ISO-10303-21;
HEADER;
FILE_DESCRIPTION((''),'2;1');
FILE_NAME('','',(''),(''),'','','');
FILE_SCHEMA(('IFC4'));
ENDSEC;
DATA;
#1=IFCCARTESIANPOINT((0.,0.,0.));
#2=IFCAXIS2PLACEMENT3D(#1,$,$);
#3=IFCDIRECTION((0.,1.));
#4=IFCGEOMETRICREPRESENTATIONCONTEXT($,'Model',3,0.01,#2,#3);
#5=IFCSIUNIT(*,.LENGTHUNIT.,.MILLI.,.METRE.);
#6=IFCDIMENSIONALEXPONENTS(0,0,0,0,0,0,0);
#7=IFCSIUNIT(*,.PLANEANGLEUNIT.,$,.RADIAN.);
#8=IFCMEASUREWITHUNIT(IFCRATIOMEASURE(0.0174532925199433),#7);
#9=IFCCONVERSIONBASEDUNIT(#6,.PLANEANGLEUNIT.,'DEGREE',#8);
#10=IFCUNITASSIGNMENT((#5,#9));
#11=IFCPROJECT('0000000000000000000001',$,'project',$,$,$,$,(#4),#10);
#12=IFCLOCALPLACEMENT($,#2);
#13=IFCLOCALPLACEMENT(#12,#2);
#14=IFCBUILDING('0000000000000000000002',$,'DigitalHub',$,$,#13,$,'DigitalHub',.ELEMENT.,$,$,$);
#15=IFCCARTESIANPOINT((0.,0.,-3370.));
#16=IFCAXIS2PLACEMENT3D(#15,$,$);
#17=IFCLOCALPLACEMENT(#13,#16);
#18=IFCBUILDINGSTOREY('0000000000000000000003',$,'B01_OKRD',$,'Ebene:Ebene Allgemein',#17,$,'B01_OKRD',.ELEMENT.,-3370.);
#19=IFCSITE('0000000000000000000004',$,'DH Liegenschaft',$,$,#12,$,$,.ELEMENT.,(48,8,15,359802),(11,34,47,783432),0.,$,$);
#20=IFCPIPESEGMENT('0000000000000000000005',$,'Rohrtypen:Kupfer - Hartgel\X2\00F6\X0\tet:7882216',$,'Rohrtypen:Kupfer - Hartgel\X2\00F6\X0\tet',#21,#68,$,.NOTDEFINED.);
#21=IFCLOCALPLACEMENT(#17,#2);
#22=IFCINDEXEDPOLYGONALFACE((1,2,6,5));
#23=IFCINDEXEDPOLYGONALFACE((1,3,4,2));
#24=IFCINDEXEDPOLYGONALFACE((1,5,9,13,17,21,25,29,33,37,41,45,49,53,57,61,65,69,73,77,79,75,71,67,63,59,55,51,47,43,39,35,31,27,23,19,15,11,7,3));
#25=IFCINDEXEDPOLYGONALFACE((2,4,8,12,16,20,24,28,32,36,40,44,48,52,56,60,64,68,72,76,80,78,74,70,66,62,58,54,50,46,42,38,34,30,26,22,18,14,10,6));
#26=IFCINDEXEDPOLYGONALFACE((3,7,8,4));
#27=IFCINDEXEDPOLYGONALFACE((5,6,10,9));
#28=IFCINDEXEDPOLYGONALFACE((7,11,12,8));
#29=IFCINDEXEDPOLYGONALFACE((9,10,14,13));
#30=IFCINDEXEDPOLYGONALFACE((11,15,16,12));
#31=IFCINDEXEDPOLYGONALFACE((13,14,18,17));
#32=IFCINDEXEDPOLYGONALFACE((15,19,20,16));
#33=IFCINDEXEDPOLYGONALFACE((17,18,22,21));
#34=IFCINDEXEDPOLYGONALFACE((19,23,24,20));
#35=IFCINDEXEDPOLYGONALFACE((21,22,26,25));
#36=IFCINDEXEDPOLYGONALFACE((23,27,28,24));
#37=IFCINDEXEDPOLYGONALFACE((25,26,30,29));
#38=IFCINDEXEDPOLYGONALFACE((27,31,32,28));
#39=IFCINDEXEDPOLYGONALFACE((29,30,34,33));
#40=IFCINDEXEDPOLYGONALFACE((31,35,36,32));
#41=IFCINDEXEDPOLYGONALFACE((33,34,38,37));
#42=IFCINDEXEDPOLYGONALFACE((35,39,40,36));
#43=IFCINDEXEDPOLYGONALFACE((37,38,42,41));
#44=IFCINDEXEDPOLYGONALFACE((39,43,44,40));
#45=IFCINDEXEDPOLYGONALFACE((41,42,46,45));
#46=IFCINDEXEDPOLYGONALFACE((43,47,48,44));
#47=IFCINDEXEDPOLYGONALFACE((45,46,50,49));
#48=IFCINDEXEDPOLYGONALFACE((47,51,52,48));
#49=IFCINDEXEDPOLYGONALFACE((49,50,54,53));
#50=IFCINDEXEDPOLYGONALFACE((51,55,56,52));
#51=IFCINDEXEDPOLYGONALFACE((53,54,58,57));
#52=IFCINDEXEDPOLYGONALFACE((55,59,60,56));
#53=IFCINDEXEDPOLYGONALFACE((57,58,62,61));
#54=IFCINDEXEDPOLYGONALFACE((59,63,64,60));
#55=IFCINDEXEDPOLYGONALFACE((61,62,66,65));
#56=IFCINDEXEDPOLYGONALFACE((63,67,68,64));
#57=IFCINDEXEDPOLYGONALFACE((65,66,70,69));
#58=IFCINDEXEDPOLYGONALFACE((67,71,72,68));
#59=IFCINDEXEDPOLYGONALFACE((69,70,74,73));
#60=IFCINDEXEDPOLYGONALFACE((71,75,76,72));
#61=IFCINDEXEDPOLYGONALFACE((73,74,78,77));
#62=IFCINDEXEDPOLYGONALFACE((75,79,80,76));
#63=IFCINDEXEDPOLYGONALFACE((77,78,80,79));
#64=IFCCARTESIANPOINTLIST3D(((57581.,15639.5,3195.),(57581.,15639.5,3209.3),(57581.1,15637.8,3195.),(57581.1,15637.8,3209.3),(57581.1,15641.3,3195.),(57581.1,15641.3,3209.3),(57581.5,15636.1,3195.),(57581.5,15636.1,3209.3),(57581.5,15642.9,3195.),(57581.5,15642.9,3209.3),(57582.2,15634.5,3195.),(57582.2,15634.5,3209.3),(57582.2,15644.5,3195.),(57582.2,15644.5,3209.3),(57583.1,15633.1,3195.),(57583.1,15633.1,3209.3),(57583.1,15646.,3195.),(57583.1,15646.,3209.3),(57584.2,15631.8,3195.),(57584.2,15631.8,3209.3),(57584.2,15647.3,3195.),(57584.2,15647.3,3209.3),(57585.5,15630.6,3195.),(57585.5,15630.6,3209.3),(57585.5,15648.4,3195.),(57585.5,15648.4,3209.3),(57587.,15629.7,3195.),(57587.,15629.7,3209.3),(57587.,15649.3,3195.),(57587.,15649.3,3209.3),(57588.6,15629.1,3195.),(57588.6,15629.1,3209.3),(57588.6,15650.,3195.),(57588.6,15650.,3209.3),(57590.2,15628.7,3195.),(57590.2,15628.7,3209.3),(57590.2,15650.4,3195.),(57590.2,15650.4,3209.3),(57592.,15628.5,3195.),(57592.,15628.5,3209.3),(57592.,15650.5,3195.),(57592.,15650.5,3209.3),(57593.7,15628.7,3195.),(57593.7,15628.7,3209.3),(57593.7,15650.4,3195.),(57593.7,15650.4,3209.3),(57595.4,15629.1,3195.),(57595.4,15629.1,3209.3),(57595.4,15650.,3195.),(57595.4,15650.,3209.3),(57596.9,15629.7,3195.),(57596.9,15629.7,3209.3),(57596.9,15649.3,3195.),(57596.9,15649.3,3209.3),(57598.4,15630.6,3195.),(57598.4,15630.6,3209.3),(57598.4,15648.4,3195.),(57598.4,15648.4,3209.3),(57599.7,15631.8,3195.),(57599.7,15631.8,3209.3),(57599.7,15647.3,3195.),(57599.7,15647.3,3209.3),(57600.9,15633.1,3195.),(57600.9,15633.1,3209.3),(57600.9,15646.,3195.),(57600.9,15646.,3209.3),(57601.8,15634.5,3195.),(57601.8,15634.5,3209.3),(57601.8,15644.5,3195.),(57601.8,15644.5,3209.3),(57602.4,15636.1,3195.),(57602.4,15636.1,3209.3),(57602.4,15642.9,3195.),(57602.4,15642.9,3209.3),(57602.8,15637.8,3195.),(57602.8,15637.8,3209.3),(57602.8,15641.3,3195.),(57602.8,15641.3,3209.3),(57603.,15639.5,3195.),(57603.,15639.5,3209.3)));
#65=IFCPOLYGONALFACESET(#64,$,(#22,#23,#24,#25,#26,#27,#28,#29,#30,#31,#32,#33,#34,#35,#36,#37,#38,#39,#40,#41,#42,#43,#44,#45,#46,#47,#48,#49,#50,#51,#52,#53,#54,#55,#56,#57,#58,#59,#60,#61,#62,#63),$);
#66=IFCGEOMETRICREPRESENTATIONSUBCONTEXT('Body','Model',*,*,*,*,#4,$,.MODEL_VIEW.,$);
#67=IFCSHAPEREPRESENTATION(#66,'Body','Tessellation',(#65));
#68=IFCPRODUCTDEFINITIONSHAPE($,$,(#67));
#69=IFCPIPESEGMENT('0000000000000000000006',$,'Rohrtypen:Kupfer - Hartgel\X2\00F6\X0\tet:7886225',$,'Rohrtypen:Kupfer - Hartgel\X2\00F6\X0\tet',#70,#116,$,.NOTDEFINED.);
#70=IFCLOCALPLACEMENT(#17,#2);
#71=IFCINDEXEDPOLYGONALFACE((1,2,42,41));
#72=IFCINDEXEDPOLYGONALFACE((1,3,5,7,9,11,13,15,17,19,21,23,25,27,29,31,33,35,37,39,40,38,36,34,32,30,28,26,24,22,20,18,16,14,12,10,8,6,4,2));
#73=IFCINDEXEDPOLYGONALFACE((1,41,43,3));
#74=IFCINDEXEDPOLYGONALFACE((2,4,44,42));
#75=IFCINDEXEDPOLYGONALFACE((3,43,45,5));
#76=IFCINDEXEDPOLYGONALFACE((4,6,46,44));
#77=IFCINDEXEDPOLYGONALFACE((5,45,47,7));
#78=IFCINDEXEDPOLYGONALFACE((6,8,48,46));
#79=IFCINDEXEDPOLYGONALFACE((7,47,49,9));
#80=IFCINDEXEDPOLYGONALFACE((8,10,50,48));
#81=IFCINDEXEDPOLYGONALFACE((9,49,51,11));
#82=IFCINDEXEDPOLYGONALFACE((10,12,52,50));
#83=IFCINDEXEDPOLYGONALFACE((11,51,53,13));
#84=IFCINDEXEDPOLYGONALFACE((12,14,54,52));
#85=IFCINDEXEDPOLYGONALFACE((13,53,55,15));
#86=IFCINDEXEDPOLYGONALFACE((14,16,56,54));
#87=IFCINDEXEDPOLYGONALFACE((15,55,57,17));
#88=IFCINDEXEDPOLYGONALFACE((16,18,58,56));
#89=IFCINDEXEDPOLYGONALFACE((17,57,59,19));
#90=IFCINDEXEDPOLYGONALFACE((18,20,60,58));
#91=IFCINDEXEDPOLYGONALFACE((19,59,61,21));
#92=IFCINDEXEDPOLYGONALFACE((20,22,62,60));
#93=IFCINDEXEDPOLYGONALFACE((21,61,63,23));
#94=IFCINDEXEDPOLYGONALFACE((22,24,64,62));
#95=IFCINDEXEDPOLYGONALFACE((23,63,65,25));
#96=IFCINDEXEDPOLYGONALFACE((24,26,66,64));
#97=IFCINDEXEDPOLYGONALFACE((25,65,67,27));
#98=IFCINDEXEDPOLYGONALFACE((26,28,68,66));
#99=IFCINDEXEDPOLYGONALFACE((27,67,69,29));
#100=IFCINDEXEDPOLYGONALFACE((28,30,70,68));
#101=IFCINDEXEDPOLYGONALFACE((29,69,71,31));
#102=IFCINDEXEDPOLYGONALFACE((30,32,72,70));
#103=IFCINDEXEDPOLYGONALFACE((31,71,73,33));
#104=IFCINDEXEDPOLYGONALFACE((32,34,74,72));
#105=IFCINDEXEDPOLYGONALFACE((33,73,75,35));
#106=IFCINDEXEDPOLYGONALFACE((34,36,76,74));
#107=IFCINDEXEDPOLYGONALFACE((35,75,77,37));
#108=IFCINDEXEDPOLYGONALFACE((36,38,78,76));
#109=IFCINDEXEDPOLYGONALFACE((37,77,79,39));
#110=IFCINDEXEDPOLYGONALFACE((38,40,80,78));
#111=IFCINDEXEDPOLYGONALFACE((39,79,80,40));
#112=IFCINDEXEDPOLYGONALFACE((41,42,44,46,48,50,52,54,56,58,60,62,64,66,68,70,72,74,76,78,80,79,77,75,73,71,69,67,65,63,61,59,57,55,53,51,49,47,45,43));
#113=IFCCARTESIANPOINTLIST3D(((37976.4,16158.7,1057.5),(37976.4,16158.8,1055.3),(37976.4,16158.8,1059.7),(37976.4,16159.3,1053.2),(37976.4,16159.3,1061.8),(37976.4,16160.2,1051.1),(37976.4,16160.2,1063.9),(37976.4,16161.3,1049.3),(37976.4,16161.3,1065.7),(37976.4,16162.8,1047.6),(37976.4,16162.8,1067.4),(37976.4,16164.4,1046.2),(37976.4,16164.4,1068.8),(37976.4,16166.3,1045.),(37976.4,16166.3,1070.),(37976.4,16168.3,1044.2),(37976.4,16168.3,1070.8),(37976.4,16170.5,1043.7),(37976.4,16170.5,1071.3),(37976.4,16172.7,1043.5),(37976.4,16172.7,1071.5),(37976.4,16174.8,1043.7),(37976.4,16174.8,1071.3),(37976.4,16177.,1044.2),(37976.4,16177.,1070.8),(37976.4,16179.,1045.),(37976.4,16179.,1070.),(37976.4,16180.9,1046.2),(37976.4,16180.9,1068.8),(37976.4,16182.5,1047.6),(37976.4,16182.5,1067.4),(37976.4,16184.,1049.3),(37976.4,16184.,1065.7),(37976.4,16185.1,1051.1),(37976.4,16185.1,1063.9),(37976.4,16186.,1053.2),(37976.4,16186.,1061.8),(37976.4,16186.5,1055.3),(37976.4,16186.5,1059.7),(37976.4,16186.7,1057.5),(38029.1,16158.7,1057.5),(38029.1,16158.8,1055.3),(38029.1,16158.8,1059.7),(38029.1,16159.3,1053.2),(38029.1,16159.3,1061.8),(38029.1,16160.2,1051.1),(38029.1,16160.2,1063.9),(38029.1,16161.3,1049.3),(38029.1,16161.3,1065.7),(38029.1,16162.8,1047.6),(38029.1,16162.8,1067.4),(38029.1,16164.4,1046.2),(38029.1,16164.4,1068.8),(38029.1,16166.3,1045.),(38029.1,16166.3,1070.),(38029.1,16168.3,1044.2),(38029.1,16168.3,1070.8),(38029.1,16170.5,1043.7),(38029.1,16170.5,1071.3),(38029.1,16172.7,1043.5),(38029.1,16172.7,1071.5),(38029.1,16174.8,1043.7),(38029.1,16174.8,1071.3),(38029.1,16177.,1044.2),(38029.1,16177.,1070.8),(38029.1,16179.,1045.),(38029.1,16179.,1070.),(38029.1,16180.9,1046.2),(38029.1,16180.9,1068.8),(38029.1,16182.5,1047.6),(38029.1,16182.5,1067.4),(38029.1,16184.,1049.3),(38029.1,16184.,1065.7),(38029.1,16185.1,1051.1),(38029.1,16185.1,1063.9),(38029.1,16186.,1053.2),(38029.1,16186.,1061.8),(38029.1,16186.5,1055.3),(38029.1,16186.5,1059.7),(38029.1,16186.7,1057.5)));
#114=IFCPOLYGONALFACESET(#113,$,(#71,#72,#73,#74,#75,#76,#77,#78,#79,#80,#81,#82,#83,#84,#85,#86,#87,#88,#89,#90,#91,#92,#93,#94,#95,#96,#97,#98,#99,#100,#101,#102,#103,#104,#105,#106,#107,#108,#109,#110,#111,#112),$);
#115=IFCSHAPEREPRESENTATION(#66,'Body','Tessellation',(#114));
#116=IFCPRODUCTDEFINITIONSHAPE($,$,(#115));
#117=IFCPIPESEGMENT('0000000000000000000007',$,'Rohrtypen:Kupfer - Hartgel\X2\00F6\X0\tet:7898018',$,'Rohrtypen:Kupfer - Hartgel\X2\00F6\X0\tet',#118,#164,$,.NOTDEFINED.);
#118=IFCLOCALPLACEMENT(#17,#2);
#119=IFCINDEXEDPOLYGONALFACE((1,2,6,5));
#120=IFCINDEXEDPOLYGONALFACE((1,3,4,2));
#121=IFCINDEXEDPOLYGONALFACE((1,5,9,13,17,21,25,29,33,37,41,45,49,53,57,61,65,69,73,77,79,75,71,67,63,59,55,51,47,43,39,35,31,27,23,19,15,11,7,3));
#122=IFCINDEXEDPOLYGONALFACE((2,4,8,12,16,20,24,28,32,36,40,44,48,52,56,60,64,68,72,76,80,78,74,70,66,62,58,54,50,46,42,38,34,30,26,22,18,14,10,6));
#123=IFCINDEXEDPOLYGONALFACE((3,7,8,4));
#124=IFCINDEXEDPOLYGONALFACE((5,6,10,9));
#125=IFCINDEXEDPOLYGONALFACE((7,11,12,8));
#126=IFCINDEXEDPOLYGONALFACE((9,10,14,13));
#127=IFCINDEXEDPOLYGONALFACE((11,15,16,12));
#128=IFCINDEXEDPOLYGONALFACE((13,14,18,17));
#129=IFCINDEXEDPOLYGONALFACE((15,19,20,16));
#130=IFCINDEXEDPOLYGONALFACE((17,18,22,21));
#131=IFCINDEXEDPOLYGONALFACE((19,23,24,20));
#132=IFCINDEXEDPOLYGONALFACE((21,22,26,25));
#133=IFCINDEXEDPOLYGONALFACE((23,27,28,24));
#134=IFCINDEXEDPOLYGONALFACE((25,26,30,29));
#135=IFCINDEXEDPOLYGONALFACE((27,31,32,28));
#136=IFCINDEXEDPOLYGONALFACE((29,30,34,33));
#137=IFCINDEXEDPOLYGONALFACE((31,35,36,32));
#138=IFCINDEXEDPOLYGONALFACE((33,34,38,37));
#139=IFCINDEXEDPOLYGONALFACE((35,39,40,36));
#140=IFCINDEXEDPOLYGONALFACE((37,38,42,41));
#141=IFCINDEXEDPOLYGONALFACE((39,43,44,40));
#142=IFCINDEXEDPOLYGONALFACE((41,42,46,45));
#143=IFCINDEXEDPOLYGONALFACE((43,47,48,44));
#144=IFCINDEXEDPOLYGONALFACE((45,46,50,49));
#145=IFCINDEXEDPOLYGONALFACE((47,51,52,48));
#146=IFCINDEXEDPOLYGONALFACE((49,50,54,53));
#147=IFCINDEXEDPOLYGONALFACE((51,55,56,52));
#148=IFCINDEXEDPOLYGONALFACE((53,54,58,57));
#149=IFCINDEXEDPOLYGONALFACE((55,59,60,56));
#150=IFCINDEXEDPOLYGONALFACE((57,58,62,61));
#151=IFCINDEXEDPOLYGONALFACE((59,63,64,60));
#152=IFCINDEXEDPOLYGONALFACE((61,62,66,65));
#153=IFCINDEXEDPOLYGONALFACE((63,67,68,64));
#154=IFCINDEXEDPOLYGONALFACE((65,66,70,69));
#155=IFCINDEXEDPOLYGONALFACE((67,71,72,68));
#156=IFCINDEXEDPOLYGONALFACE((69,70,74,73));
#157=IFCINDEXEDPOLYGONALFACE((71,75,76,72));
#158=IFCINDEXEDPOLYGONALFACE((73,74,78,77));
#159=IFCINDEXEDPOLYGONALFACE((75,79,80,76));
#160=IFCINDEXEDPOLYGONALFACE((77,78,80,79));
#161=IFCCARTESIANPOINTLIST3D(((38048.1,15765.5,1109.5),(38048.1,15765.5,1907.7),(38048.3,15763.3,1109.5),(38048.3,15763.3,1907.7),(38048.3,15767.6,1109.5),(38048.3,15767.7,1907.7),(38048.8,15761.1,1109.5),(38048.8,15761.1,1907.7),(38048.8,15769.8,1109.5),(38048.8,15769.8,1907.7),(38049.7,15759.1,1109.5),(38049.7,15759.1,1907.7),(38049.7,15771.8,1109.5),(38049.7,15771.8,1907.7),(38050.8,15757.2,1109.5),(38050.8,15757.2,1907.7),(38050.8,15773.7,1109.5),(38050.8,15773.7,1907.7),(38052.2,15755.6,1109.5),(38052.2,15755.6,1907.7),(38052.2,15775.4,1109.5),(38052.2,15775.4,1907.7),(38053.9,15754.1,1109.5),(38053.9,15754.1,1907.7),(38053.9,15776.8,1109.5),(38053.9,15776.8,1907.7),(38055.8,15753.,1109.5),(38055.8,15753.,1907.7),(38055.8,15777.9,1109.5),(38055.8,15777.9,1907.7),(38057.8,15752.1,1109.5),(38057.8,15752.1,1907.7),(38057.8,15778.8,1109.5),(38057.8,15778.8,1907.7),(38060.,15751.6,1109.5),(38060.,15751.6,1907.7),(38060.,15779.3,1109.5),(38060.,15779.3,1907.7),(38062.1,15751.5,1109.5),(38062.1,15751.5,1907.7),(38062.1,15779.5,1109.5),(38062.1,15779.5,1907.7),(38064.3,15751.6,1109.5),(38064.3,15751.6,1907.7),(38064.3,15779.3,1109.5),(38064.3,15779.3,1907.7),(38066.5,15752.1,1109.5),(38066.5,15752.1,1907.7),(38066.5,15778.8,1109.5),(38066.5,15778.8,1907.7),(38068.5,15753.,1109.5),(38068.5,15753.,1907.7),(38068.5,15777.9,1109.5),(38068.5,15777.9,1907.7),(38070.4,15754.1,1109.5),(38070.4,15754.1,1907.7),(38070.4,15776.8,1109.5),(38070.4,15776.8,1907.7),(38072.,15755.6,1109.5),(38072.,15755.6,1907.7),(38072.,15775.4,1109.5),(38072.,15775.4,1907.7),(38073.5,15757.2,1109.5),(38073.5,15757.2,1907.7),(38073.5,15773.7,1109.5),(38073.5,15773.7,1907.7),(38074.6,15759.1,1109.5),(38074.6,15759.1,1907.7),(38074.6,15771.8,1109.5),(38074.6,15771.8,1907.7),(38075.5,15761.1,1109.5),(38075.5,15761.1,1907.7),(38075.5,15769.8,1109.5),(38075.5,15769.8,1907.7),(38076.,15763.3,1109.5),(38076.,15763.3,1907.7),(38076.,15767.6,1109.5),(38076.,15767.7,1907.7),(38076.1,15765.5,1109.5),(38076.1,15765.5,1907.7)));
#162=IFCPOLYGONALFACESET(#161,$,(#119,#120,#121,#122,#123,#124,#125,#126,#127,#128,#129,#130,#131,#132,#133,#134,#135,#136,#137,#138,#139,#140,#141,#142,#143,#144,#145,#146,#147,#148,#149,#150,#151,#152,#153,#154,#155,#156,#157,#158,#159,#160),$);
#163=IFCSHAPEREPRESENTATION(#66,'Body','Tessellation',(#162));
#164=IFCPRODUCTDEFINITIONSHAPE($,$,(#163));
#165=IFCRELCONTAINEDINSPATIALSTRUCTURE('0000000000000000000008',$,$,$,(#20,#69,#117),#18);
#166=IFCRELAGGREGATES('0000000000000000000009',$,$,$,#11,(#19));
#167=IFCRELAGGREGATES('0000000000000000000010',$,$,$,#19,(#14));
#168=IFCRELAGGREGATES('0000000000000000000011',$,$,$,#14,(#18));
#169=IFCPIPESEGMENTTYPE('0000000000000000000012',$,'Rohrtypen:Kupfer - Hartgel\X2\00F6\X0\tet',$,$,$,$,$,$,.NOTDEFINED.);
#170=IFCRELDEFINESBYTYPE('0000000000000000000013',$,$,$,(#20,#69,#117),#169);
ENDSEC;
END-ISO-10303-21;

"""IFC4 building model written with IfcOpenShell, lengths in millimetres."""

from ifc_helpers import new_model, entity, si_unit, converted_unit, direction, frame, origin, place, context, subcontext, project, spatial, indexed_curve, outline, extrude, type_object, element, save


model = new_model("IFC4")

# Units and contexts
model_context = context("Model", 3, precision=0.01, world=origin(), true_north=direction((0.0, 1.0)))
body_context = subcontext(model_context, "Body", "Model", "MODEL_VIEW")
ifc_project = project(units=[si_unit("LENGTHUNIT", "METRE", prefix="MILLI"), converted_unit("PLANEANGLEUNIT", "DEGREE", entity("IfcRatioMeasure", 0.0174532925199433), si_unit("PLANEANGLEUNIT", "RADIAN"), dimensions=[0, 0, 0, 0, 0, 0, 0])], contexts=[model_context])

# Site, building, storey
site_placement = place(None, origin())
site = spatial("IfcSite", under=ifc_project, at=site_placement, Name="DH Liegenschaft", CompositionType="ELEMENT", RefLatitude=(48, 8, 15, 359802), RefLongitude=(11, 34, 47, 783432), RefElevation=0.0)
building_placement = place(site_placement, origin())
building = spatial("IfcBuilding", under=site, at=building_placement, Name="DigitalHub", LongName="DigitalHub", CompositionType="ELEMENT")
storey_placement = place(building_placement, frame((0.0, 0.0, -3370.0)))
storey = spatial("IfcBuildingStorey", under=building, at=storey_placement, Name="B01_OKRD", ObjectType="Ebene:Ebene Allgemein", LongName="B01_OKRD", CompositionType="ELEMENT", Elevation=-3370.0)

# Pipe segments
pipe_segment_type = type_object("IfcPipeSegmentType", Name="Rohrtypen:Kupfer - Hartgelötet", PredefinedType="NOTDEFINED")
pipe_segment_1_placement = place(storey_placement, frame((57579.4, 15626.9, 3195.0)))
element("IfcPipeSegment", 1, at=pipe_segment_1_placement, inside=storey, type_object=pipe_segment_type, Name="Rohrtypen:Kupfer - Hartgelötet:7882216", ObjectType="Rohrtypen:Kupfer - Hartgelötet", PredefinedType="NOTDEFINED", context=body_context, shape_type="SweptSolid", body=[
    extrude(outline(indexed_curve([(11.0, 0.0), (10.9, 1.7), (10.5, 3.4), (9.8, 5.0), (8.9, 6.5), (7.8, 7.8), (6.5, 8.9), (5.0, 9.8), (3.4, 10.5), (1.7, 10.9), (0.0, 11.0), (-1.7, 10.9), (-3.4, 10.5), (-5.0, 9.8), (-6.5, 8.9), (-7.8, 7.8), (-8.9, 6.5), (-9.8, 5.0), (-10.5, 3.4), (-10.9, 1.7), (-11.0, 0.0), (-10.9, -1.7), (-10.5, -3.4), (-9.8, -5.0), (-8.9, -6.5), (-7.8, -7.8), (-6.5, -8.9), (-5.0, -9.8), (-3.4, -10.5), (-1.7, -10.9), (0.0, -11.0), (1.7, -10.9), (3.4, -10.5), (5.0, -9.8), (6.5, -8.9), (7.8, -7.8), (8.9, -6.5), (9.8, -5.0), (10.5, -3.4), (10.9, -1.7), (11.0, 0.0)], self_intersect=False)), frame((12.6, 12.6, 0.0)), (0.0, 0.0, 1.0), 14.3),
])
pipe_segment_2_placement = place(storey_placement, frame((37976.4, 16157.1, 1041.9)))
element("IfcPipeSegment", 2, at=pipe_segment_2_placement, inside=storey, type_object=pipe_segment_type, Name="Rohrtypen:Kupfer - Hartgelötet:7886225", ObjectType="Rohrtypen:Kupfer - Hartgelötet", PredefinedType="NOTDEFINED", context=body_context, shape_type="SweptSolid", body=[
    extrude(outline(indexed_curve([(14.0, 0.0), (13.8, 2.2), (13.3, 4.3), (12.5, 6.4), (11.3, 8.2), (9.9, 9.9), (8.2, 11.3), (6.4, 12.5), (4.3, 13.3), (2.2, 13.8), (0.0, 14.0), (-2.2, 13.8), (-4.3, 13.3), (-6.4, 12.5), (-8.2, 11.3), (-9.9, 9.9), (-11.3, 8.2), (-12.5, 6.4), (-13.3, 4.3), (-13.8, 2.2), (-14.0, 0.0), (-13.8, -2.2), (-13.3, -4.3), (-12.5, -6.4), (-11.3, -8.2), (-9.9, -9.9), (-8.2, -11.3), (-6.4, -12.5), (-4.3, -13.3), (-2.2, -13.8), (0.0, -14.0), (2.2, -13.8), (4.3, -13.3), (6.4, -12.5), (8.2, -11.3), (9.9, -9.9), (11.3, -8.2), (12.5, -6.4), (13.3, -4.3), (13.8, -2.2), (14.0, 0.0)], self_intersect=False)), frame((52.7, 15.6, 15.6), z_axis=(-1.0, 0.0, 0.000072), x_axis=(0.0, 1.0, 0.0)), (0.0, 0.0, 1.0), 52.7),
])
pipe_segment_3_placement = place(storey_placement, frame((38046.6, 15749.9, 1109.5)))
element("IfcPipeSegment", 3, at=pipe_segment_3_placement, inside=storey, type_object=pipe_segment_type, Name="Rohrtypen:Kupfer - Hartgelötet:7898018", ObjectType="Rohrtypen:Kupfer - Hartgelötet", PredefinedType="NOTDEFINED", context=body_context, shape_type="SweptSolid", body=[
    extrude(outline(indexed_curve([(14.0, 0.0), (13.8, 2.2), (13.3, 4.3), (12.5, 6.4), (11.3, 8.2), (9.9, 9.9), (8.2, 11.3), (6.4, 12.5), (4.3, 13.3), (2.2, 13.8), (0.0, 14.0), (-2.2, 13.8), (-4.3, 13.3), (-6.4, 12.5), (-8.2, 11.3), (-9.9, 9.9), (-11.3, 8.2), (-12.5, 6.4), (-13.3, 4.3), (-13.8, 2.2), (-14.0, 0.0), (-13.8, -2.2), (-13.3, -4.3), (-12.5, -6.4), (-11.3, -8.2), (-9.9, -9.9), (-8.2, -11.3), (-6.4, -12.5), (-4.3, -13.3), (-2.2, -13.8), (0.0, -14.0), (2.2, -13.8), (4.3, -13.3), (6.4, -12.5), (8.2, -11.3), (9.9, -9.9), (11.3, -8.2), (12.5, -6.4), (13.3, -4.3), (13.8, -2.2), (14.0, 0.0)], self_intersect=False)), frame((15.6, 15.6, 0.0), z_axis=(0.0, 0.000002, 1.0), x_axis=(-1.0, 0.0, 0.0)), (0.0, 0.0, 1.0), 798.2),
])

save(model, "model.ifc")
